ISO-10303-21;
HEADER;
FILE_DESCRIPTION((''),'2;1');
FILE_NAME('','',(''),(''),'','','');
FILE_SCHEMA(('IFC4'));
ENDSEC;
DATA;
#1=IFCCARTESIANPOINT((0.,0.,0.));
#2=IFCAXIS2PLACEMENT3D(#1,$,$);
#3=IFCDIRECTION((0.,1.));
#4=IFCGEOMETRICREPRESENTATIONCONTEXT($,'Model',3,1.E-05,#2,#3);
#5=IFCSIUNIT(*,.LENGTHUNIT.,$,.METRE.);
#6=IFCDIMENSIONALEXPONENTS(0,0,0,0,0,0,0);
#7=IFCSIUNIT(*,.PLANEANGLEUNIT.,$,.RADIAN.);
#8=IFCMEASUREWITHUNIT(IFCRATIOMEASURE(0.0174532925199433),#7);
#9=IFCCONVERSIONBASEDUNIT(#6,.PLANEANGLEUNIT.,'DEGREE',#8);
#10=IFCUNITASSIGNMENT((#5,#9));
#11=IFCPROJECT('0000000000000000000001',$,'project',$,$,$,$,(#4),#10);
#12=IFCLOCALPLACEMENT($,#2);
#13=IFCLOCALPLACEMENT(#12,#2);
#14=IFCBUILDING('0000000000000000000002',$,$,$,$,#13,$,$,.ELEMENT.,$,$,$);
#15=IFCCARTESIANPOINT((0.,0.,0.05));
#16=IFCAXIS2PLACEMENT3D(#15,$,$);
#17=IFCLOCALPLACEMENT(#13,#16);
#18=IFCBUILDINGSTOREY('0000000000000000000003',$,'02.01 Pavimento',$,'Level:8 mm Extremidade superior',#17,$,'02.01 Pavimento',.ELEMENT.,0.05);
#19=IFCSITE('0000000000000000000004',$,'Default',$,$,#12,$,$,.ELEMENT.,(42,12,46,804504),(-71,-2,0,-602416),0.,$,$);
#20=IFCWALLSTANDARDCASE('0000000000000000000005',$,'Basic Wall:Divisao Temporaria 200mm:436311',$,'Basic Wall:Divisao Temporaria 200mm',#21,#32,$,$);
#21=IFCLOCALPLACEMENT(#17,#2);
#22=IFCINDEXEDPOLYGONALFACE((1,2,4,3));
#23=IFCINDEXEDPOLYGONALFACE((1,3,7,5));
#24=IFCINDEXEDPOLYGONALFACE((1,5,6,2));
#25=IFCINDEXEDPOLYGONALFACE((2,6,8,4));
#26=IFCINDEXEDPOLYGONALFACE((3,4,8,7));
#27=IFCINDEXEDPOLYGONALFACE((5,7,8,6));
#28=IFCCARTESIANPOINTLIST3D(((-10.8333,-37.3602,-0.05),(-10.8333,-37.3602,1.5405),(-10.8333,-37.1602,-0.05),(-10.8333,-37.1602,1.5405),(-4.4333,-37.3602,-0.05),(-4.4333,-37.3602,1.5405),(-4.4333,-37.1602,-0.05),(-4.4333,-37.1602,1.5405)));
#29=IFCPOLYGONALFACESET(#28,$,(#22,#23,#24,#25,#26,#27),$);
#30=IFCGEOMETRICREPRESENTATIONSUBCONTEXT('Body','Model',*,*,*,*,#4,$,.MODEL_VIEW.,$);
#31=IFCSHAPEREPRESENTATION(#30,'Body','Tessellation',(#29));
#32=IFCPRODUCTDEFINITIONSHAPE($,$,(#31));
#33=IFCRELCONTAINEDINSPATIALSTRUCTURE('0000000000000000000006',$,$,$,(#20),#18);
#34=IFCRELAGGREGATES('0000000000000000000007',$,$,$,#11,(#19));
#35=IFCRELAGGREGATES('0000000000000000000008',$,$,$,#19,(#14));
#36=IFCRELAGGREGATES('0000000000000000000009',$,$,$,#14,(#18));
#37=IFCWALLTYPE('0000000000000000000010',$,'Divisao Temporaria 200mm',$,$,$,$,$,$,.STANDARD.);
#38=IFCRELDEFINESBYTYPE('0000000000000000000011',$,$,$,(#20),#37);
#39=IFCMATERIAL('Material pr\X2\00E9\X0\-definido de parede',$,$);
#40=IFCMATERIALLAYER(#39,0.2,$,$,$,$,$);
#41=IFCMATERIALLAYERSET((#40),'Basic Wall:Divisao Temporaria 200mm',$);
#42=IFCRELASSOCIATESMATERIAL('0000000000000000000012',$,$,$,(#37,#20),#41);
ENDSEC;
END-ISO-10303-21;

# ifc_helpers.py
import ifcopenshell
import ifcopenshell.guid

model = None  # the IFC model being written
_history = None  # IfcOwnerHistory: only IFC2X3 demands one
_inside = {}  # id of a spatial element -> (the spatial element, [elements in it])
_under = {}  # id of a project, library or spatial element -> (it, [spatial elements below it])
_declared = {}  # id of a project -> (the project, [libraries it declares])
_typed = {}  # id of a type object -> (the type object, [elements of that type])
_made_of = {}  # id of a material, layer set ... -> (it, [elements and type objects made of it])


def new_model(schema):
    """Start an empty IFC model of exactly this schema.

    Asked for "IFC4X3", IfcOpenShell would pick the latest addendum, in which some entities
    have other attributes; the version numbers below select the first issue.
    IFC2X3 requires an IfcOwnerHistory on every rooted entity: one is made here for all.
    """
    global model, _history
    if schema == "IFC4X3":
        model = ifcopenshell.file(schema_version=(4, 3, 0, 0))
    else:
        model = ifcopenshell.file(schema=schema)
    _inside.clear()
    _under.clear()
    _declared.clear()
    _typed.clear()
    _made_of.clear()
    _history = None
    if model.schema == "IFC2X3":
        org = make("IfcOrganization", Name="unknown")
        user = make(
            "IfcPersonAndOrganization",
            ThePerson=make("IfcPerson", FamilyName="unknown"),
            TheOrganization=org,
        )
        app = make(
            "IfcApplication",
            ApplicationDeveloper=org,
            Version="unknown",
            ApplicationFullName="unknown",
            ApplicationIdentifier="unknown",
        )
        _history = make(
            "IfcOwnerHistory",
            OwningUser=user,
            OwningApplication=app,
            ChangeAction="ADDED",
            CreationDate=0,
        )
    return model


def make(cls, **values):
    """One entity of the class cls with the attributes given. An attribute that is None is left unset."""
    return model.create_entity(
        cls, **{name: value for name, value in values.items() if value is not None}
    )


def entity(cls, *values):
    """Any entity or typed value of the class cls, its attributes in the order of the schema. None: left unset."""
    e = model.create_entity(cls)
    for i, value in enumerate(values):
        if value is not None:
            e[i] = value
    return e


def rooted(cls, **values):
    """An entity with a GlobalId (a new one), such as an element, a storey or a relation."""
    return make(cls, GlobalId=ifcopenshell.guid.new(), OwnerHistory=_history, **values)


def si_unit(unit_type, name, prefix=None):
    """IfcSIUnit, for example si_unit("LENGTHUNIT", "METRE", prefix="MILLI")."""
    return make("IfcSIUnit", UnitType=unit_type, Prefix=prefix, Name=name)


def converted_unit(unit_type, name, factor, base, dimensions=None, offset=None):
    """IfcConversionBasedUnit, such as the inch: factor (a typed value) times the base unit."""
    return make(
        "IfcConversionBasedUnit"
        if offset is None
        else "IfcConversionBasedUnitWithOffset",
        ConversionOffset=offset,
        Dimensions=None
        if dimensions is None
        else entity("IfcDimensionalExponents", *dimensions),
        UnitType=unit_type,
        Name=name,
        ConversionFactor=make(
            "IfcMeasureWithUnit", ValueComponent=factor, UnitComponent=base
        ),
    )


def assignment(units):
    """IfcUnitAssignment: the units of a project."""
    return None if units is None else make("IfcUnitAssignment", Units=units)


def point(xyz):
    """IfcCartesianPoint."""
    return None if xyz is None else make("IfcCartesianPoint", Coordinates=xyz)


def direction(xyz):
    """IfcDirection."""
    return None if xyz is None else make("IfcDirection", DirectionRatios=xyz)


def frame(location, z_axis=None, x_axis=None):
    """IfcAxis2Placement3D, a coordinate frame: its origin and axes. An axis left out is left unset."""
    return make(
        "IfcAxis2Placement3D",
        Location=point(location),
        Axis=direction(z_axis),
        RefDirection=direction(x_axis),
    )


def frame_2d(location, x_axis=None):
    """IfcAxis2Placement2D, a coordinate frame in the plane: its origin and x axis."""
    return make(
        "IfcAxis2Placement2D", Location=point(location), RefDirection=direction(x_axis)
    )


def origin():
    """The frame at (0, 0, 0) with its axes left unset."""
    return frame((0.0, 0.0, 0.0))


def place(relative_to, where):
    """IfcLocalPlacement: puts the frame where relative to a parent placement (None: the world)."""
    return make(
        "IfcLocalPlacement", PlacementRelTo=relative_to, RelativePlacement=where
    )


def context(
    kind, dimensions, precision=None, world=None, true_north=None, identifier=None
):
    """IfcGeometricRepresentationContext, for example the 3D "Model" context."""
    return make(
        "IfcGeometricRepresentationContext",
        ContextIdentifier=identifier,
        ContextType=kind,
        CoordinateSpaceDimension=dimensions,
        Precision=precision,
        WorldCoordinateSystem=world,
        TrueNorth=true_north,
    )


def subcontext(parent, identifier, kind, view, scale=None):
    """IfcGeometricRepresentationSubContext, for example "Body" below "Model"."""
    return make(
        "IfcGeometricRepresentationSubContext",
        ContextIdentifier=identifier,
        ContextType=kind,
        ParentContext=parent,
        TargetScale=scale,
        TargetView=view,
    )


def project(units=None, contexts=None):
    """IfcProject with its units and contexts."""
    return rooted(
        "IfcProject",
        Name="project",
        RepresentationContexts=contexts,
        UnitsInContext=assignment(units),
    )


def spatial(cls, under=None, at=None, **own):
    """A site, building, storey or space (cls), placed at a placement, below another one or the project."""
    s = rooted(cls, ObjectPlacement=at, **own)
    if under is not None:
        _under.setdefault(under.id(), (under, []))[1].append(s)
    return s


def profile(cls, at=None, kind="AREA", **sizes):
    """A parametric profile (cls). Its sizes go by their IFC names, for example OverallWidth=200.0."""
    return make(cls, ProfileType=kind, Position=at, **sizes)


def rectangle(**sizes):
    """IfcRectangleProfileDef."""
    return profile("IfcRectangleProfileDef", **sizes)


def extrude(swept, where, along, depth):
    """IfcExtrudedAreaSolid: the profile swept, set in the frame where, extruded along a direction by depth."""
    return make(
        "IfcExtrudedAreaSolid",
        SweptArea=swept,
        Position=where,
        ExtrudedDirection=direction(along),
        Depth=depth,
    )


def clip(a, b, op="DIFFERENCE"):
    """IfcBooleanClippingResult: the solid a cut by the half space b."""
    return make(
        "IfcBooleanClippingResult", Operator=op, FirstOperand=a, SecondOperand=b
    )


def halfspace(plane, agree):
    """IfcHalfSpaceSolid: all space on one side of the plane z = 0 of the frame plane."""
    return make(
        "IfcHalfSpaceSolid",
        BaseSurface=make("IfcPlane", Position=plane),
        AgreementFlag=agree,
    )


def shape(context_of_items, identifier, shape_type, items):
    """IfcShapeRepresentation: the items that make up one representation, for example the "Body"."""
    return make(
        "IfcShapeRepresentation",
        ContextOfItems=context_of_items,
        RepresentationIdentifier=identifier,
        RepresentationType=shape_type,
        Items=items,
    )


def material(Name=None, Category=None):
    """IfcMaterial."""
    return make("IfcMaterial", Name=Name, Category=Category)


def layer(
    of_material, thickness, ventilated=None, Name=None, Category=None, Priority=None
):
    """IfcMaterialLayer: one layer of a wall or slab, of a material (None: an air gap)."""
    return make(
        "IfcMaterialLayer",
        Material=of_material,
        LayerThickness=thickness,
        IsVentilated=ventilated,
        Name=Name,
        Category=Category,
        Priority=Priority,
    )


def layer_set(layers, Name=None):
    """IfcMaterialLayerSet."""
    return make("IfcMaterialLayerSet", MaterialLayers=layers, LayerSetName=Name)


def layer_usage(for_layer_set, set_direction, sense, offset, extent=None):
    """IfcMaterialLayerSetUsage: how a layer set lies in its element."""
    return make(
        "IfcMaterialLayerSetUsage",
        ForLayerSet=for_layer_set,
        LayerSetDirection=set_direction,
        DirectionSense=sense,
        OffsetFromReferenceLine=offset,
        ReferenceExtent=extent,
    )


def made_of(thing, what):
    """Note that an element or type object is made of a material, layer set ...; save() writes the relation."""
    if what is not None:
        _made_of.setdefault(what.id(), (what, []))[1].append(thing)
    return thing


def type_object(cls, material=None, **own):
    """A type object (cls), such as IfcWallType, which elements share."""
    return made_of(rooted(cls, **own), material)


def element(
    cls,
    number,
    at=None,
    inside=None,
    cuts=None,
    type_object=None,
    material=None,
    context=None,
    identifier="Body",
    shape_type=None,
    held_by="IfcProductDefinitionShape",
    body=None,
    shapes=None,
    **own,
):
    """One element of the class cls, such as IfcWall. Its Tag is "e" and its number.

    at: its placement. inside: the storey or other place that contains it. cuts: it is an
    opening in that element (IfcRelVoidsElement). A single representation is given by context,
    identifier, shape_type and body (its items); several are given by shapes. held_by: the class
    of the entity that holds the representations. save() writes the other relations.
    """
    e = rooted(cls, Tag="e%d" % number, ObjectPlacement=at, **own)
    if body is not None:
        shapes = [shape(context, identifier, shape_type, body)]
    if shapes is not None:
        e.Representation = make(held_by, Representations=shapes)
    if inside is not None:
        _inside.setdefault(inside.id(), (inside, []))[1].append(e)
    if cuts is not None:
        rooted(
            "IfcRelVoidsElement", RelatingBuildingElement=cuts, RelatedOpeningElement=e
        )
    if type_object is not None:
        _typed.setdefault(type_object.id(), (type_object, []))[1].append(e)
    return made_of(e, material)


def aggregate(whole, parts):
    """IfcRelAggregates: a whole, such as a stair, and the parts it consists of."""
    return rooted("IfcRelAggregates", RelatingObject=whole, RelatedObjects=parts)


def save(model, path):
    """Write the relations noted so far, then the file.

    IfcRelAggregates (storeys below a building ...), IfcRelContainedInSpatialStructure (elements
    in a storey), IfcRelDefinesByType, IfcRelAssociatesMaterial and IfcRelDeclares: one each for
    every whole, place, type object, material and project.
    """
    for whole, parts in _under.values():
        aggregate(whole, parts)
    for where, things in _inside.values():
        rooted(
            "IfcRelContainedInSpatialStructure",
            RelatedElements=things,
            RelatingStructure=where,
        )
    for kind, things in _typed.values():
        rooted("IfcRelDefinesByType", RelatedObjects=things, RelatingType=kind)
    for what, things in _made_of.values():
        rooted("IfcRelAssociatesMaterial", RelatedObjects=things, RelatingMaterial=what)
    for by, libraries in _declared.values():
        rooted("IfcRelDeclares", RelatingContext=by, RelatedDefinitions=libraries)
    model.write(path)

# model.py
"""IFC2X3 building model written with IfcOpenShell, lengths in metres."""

from ifc_helpers import new_model, entity, si_unit, converted_unit, direction, frame, frame_2d, origin, place, context, subcontext, project, spatial, rectangle, extrude, clip, halfspace, material, layer, layer_set, layer_usage, type_object, element, save


model = new_model("IFC2X3")

# Units and contexts
model_context = context("Model", 3, precision=1e-05, world=origin(), true_north=direction((0.0, 1.0)))
body_context = subcontext(model_context, "Body", "Model", "MODEL_VIEW")
ifc_project = project(units=[si_unit("LENGTHUNIT", "METRE"), converted_unit("PLANEANGLEUNIT", "DEGREE", entity("IfcRatioMeasure", 0.0174532925199433), si_unit("PLANEANGLEUNIT", "RADIAN"), dimensions=[0, 0, 0, 0, 0, 0, 0])], contexts=[model_context])

# Site, building, storey
site_placement = place(None, origin())
site = spatial("IfcSite", under=ifc_project, at=site_placement, Name="Default", CompositionType="ELEMENT", RefLatitude=(42, 12, 46, 804504), RefLongitude=(-71, -2, 0, -602416), RefElevation=0.0)
building_placement = place(site_placement, origin())
building = spatial("IfcBuilding", under=site, at=building_placement, CompositionType="ELEMENT")
storey_placement = place(building_placement, frame((0.0, 0.0, 0.05)))
storey = spatial("IfcBuildingStorey", under=building, at=storey_placement, Name="02.01 Pavimento", ObjectType="Level:8 mm Extremidade superior", LongName="02.01 Pavimento", CompositionType="ELEMENT", Elevation=0.05)

# Shared definitions
ifc_material_1 = material(Name="Material pré-definido de parede")

# Shared definitions
ifc_layer_1 = layer(ifc_material_1, 0.2)
ifc_layer_set_1 = layer_set([ifc_layer_1], Name="Basic Wall:Divisao Temporaria 200mm")
wall_type_1 = type_object("IfcWallType", Name="Divisao Temporaria 200mm", PredefinedType="STANDARD", material=ifc_layer_set_1)

# Wall
ifc_layer_usage_1 = layer_usage(ifc_layer_set_1, "AXIS2", "POSITIVE", -0.1)
wall_1_placement = place(storey_placement, frame((-4.4333, -37.2602, -0.05), z_axis=(0.0, 0.0, 1.0), x_axis=(-1.0, 0.0, 0.0)))
element("IfcWallStandardCase", 1, at=wall_1_placement, inside=storey, type_object=wall_type_1, material=ifc_layer_usage_1, Name="Basic Wall:Divisao Temporaria 200mm:436311", ObjectType="Basic Wall:Divisao Temporaria 200mm", context=body_context, shape_type="Clipping", body=[
    clip(extrude(rectangle(XDim=6.4, YDim=0.2, at=frame_2d((3.2, 0.0), x_axis=(-1.0, 0.0))), origin(), (0.0, 0.0, 1.0), 1.5905), halfspace(frame((0.0, 0.0, -0.05)), True)),
])

save(model, "model.ifc")
